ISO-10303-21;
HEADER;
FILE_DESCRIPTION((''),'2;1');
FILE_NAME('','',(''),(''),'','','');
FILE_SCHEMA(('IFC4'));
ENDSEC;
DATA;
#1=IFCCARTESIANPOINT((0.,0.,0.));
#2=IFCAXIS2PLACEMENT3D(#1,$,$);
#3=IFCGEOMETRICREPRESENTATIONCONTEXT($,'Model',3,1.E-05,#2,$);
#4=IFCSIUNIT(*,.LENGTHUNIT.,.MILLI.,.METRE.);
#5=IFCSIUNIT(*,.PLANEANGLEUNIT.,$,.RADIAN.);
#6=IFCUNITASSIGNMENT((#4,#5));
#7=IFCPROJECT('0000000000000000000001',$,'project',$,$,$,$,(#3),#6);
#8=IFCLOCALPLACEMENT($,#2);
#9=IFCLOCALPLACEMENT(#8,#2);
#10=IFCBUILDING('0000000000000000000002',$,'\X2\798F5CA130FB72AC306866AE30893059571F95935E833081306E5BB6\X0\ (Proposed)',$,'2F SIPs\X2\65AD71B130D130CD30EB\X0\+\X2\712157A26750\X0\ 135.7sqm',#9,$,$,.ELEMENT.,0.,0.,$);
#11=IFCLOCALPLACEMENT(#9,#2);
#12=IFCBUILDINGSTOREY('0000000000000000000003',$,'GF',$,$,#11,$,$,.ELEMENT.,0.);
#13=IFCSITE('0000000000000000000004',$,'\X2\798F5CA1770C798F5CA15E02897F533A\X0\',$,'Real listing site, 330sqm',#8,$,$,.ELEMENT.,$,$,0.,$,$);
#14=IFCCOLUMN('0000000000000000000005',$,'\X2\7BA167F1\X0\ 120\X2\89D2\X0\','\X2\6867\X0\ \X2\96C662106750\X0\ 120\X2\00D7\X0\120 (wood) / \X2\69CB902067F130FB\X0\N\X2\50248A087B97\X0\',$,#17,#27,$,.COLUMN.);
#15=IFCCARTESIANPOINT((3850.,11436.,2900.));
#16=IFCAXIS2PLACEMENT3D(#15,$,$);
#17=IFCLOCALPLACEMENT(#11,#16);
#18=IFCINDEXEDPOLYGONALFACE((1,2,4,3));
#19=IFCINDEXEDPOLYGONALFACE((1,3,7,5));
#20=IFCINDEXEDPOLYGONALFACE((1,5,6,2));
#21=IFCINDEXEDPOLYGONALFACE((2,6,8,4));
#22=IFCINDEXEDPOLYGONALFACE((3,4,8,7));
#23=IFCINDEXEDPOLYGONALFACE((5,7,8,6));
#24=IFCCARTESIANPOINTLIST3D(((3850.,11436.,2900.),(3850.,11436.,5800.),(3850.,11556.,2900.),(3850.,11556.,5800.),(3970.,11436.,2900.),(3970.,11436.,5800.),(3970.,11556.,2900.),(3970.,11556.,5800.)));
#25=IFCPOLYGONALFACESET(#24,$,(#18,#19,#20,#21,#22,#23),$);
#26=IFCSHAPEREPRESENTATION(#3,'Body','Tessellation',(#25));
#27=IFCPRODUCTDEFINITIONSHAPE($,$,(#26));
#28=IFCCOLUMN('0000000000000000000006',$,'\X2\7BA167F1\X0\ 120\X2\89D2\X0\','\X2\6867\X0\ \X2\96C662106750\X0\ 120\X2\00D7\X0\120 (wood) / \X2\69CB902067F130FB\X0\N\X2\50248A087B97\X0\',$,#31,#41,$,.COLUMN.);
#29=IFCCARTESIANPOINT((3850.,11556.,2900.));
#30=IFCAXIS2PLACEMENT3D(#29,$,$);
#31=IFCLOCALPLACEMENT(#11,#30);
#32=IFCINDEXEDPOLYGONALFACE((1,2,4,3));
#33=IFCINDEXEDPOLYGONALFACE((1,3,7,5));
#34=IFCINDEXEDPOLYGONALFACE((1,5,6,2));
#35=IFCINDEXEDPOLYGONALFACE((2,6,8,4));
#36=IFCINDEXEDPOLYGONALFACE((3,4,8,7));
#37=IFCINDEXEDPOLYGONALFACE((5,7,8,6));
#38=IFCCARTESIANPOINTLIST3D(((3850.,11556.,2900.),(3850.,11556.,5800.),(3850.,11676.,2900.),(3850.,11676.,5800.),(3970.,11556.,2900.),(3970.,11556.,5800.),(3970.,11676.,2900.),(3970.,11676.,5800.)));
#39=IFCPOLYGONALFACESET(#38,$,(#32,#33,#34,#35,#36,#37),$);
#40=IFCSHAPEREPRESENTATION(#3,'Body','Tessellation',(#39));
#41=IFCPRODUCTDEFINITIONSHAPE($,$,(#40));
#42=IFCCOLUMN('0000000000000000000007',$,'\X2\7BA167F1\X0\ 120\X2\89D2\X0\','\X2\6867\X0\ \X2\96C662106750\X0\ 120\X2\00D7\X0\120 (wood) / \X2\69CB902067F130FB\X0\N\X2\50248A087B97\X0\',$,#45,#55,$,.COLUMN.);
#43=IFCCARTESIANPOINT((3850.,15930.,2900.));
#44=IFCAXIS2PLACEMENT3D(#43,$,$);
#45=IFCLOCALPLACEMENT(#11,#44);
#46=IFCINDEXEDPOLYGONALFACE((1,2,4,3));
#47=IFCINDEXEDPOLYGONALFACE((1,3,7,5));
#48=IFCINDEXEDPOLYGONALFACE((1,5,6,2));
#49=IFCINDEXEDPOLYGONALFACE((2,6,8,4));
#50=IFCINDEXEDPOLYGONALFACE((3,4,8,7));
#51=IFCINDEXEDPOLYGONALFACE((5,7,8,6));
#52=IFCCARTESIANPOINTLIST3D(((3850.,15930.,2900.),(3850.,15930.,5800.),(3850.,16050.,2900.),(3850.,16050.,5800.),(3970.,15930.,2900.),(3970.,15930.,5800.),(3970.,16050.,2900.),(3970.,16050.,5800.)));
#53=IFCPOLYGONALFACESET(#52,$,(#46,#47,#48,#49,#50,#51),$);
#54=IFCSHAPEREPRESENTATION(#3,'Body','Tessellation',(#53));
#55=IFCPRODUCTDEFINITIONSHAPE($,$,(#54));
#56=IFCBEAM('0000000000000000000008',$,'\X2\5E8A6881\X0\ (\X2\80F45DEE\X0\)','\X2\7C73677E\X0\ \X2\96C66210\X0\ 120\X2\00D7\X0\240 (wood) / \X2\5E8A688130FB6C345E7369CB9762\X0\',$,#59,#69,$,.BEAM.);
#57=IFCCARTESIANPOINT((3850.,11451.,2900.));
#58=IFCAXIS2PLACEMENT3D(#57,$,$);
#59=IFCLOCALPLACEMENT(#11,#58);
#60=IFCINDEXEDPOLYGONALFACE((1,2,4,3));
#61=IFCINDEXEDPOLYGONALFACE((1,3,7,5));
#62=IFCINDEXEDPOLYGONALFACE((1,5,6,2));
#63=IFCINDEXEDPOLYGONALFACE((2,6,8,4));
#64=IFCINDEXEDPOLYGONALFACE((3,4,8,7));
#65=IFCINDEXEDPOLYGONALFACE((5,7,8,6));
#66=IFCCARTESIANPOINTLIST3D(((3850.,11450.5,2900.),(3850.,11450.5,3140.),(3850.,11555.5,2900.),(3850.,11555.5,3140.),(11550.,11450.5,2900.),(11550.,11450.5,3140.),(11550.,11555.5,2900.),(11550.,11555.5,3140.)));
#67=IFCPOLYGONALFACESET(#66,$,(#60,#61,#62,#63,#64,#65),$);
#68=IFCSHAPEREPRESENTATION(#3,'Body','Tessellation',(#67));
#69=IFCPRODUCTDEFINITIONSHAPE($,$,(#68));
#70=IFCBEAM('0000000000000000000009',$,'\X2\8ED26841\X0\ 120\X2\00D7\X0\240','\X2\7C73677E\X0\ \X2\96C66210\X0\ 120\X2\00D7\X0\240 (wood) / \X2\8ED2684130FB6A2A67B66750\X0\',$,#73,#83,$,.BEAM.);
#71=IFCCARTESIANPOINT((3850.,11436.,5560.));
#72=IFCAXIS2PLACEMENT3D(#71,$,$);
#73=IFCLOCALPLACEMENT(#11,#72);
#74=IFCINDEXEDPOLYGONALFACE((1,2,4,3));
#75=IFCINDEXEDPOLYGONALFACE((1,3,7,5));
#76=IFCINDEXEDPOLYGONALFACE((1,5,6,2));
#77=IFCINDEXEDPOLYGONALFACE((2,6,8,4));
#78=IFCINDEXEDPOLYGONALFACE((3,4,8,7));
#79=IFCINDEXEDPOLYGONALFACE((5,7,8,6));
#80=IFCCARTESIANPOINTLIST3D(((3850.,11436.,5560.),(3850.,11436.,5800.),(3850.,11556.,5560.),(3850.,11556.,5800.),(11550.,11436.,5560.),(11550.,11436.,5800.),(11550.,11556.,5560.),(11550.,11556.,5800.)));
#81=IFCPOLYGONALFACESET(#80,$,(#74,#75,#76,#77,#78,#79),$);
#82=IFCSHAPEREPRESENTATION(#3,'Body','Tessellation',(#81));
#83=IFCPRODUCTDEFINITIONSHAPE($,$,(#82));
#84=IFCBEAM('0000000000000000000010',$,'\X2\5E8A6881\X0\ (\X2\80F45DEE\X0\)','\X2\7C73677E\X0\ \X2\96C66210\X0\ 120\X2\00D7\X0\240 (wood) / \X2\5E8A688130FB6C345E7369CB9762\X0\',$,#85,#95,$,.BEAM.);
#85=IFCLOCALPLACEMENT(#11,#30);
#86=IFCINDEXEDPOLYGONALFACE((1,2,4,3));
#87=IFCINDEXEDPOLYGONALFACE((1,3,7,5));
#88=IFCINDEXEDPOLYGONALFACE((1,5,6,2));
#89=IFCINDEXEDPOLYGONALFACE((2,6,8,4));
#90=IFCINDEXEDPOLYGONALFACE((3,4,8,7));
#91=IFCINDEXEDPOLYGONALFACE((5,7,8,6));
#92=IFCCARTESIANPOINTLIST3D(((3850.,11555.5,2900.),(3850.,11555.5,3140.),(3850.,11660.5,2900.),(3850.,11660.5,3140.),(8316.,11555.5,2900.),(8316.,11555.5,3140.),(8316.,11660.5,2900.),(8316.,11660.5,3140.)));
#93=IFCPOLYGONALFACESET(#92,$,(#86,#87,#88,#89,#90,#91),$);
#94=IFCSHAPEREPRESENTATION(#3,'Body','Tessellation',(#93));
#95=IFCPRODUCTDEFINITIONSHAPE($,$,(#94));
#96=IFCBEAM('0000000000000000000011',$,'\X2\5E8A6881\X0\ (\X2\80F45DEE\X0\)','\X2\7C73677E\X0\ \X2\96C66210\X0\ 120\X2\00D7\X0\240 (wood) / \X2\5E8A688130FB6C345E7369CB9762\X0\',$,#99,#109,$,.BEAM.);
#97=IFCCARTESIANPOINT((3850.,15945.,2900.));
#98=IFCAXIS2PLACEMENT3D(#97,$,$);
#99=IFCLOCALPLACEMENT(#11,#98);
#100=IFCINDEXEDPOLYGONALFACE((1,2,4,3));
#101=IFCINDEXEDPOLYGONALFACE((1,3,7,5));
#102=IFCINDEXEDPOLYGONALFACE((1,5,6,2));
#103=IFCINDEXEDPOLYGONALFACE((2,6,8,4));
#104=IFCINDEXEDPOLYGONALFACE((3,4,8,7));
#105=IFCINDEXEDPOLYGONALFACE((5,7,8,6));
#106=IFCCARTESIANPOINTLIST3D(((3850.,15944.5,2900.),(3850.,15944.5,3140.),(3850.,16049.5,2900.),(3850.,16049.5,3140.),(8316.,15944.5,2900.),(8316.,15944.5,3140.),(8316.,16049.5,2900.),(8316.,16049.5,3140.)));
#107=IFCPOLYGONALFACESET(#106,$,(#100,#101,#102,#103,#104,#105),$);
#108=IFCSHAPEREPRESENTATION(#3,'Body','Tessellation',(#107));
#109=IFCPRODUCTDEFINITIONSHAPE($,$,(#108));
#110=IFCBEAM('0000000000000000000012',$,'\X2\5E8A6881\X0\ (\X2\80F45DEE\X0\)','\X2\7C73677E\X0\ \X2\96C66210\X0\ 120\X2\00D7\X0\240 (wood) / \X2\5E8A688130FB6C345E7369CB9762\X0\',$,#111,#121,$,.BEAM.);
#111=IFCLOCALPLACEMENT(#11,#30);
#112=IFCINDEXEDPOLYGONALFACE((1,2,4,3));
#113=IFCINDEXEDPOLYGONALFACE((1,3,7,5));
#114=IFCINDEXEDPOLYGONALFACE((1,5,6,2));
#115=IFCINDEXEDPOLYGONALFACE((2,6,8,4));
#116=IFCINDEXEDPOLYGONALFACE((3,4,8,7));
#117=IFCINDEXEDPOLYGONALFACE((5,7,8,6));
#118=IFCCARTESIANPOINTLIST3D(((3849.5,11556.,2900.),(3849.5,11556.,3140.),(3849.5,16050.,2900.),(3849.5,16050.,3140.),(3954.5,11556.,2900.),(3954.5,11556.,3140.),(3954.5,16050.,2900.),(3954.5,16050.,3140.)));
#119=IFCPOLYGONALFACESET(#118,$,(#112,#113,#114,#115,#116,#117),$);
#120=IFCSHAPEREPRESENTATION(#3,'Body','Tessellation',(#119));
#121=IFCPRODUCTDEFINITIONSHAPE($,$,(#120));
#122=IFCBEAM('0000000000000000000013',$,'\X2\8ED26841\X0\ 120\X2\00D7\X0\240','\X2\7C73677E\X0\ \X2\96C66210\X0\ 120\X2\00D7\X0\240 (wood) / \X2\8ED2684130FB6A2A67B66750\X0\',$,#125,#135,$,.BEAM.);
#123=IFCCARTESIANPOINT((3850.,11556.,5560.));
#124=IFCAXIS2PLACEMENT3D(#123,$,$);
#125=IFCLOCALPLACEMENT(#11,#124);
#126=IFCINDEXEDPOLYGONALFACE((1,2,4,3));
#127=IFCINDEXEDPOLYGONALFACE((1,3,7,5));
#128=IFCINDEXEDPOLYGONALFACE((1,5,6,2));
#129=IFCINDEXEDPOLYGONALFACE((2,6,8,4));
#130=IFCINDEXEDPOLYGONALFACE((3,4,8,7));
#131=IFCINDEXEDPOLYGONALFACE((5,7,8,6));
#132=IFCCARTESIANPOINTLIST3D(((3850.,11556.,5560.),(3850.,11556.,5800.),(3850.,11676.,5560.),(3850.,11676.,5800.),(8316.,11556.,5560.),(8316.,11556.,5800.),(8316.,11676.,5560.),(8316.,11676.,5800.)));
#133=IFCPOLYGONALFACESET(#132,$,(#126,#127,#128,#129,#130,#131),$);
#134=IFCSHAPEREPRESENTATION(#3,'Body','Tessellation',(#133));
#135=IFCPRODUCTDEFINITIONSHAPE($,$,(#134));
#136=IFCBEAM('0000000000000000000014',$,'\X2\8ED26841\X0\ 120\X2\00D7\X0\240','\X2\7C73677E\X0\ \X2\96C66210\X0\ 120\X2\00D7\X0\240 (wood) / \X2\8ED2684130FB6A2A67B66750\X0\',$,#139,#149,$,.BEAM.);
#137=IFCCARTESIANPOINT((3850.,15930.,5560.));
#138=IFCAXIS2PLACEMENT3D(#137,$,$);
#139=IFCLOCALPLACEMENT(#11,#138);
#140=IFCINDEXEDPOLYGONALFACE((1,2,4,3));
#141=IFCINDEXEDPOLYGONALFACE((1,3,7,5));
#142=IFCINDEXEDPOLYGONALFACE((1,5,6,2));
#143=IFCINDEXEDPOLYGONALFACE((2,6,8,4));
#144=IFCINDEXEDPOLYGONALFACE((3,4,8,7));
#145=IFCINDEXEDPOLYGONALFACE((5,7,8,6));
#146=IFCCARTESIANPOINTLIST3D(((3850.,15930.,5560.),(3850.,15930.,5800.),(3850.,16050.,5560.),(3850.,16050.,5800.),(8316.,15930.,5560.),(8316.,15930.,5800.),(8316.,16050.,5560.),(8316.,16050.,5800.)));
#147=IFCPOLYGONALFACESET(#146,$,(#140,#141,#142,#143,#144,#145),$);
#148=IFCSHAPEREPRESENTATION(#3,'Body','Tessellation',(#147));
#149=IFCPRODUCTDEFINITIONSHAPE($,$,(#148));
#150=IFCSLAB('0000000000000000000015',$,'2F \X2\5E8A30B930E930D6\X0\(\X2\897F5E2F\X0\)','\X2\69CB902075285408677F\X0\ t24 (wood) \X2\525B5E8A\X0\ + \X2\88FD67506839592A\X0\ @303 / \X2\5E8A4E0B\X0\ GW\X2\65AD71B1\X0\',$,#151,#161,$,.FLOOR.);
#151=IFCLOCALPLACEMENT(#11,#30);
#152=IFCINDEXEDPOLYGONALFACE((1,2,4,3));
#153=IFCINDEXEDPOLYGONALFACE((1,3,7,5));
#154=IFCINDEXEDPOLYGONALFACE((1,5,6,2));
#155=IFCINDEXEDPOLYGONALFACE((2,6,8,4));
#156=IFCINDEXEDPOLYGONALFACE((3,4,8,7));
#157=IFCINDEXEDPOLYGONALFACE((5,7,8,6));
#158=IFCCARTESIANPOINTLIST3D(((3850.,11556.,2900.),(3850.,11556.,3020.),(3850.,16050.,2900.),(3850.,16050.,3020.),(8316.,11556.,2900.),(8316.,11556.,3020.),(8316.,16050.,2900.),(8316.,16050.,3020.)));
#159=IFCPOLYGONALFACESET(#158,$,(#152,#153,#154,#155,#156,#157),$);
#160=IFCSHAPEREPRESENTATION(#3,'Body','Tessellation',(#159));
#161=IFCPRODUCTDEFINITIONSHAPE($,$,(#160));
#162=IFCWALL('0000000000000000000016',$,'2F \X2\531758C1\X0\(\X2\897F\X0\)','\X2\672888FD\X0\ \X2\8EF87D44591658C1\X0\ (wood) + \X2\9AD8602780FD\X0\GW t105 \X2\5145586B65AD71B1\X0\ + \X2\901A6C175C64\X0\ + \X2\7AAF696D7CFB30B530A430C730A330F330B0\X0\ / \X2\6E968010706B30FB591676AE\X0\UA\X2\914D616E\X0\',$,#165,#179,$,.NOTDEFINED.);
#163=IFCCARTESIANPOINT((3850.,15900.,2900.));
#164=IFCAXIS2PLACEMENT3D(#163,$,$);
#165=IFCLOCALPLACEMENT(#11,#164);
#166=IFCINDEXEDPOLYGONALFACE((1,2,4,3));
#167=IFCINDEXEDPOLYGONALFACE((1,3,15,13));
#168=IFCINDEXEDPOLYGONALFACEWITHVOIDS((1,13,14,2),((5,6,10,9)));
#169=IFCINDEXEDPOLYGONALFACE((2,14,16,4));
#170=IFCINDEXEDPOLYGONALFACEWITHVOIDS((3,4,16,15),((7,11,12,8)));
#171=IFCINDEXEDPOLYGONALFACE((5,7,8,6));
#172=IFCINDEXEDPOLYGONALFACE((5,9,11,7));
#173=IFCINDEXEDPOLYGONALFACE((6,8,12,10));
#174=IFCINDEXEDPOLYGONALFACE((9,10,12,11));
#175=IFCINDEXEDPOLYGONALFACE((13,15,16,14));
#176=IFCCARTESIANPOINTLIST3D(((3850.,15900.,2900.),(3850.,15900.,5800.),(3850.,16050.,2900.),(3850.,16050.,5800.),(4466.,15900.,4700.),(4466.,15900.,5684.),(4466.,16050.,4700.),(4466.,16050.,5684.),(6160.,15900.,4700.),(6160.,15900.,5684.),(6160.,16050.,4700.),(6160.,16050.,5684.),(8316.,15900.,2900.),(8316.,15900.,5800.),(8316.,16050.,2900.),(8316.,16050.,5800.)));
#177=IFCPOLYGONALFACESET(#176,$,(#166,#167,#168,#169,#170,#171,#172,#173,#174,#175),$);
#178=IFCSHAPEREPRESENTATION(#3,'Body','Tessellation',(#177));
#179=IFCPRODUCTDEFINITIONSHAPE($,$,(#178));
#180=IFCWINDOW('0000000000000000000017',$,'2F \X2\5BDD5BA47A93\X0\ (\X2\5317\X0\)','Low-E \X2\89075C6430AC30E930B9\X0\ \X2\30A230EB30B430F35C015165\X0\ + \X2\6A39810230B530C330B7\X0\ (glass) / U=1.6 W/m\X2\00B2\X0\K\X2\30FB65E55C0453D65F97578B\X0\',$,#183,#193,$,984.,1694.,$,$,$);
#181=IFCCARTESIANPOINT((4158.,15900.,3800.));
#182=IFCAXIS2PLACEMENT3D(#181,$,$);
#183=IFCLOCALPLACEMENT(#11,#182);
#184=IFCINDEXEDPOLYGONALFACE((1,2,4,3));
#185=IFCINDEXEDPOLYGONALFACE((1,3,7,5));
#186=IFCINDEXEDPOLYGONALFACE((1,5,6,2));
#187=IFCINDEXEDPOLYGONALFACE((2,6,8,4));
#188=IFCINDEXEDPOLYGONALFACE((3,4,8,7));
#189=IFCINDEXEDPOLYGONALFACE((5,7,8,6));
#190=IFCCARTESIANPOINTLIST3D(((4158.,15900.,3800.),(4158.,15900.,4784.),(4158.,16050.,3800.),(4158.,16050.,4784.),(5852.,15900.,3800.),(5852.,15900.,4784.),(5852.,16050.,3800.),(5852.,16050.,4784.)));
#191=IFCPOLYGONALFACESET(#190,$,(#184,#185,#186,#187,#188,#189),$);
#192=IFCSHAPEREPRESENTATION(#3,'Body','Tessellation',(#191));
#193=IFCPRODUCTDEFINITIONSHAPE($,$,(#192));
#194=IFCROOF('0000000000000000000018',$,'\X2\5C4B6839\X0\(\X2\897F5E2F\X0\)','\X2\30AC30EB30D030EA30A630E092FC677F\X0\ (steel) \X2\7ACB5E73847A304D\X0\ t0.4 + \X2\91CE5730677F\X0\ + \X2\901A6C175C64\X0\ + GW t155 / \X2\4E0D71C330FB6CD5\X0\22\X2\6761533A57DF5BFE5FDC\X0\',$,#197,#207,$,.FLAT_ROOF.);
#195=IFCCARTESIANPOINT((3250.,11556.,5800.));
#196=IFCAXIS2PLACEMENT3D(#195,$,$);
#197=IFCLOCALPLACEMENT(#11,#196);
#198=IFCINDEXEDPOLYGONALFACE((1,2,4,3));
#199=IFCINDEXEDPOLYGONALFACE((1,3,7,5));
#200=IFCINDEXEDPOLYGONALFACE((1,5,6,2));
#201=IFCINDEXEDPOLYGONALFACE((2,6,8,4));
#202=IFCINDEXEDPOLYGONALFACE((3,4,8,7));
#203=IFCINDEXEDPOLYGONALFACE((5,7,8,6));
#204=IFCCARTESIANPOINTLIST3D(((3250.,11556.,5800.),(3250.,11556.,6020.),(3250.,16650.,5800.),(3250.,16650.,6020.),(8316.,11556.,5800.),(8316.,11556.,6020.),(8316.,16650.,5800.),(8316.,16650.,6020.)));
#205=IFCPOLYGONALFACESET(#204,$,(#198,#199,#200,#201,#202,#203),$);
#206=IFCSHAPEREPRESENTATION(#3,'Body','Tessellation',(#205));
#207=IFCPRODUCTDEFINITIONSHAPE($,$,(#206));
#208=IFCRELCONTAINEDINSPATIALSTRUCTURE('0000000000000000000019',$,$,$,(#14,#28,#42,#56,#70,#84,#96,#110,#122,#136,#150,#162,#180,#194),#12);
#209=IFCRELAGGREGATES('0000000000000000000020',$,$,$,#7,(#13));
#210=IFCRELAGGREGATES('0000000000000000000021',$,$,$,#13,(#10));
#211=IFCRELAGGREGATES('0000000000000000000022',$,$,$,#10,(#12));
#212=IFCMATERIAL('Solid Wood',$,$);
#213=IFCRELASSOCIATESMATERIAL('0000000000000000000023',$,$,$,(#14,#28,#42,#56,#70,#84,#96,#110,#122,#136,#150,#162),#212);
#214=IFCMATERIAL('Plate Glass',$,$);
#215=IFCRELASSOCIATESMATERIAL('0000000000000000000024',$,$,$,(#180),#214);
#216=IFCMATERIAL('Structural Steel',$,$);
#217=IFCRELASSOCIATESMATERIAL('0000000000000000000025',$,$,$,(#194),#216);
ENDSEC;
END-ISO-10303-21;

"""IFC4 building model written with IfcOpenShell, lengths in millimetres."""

from ifc_helpers import new_model, si_unit, frame, frame_2d, origin, place, context, project, spatial, rectangle, extrude, material, element, fill, save


model = new_model("IFC4")

# Units and contexts
model_context = context("Model", 3, precision=1e-05, world=origin())
ifc_project = project(units=[si_unit("LENGTHUNIT", "METRE", prefix="MILLI"), si_unit("PLANEANGLEUNIT", "RADIAN")], contexts=[model_context])

# Site, building, storey
site_placement = place(None, origin())
site = spatial("IfcSite", under=ifc_project, at=site_placement, Name="福岡県福岡市西区", ObjectType="Real listing site, 330sqm", CompositionType="ELEMENT", RefElevation=0.0)
building_placement = place(site_placement, origin())
building = spatial("IfcBuilding", under=site, at=building_placement, Name="福岡・犬と暮らす土間広めの家 (Proposed)", ObjectType="2F SIPs断熱パネル+無垢材 135.7sqm", CompositionType="ELEMENT", ElevationOfRefHeight=0.0, ElevationOfTerrain=0.0)
storey_placement = place(building_placement, origin())
storey = spatial("IfcBuildingStorey", under=building, at=storey_placement, Name="GF", CompositionType="ELEMENT", Elevation=0.0)

# Columns
ifc_material_1 = material(Name="Solid Wood")
column_1_placement = place(storey_placement, frame((3850.0, 11436.0, 2900.0)))
element("IfcColumn", 1, at=column_1_placement, inside=storey, material=ifc_material_1, Name="管柱 120角", Description="桧 集成材 120×120 (wood) / 構造柱・N値計算", PredefinedType="COLUMN", context=model_context, shape_type="SweptSolid", body=[
    extrude(rectangle(XDim=120.0, YDim=120.0, at=frame_2d((60.0, 60.0))), frame((3850.0, 11436.0, 2900.0)), (0.0, 0.0, 1.0), 2900.0),
])
column_2_placement = place(storey_placement, frame((3850.0, 11556.0, 2900.0)))
element("IfcColumn", 2, at=column_2_placement, inside=storey, material=ifc_material_1, Name="管柱 120角", Description="桧 集成材 120×120 (wood) / 構造柱・N値計算", PredefinedType="COLUMN", context=model_context, shape_type="SweptSolid", body=[
    extrude(rectangle(XDim=120.0, YDim=120.0, at=frame_2d((60.0, 60.0))), frame((3850.0, 11556.0, 2900.0)), (0.0, 0.0, 1.0), 2900.0),
])
column_3_placement = place(storey_placement, frame((3850.0, 15930.0, 2900.0)))
element("IfcColumn", 3, at=column_3_placement, inside=storey, material=ifc_material_1, Name="管柱 120角", Description="桧 集成材 120×120 (wood) / 構造柱・N値計算", PredefinedType="COLUMN", context=model_context, shape_type="SweptSolid", body=[
    extrude(rectangle(XDim=120.0, YDim=120.0, at=frame_2d((60.0, 60.0))), frame((3850.0, 15930.0, 2900.0)), (0.0, 0.0, 1.0), 2900.0),
])

# Beams
beam_1_placement = place(storey_placement, frame((3850.0, 11451.0, 2900.0)))
element("IfcBeam", 4, at=beam_1_placement, inside=storey, material=ifc_material_1, Name="床梁 (胴差)", Description="米松 集成 120×240 (wood) / 床梁・水平構面", PredefinedType="BEAM", context=model_context, shape_type="SweptSolid", body=[
    extrude(rectangle(XDim=7700.0, YDim=105.0, at=frame_2d((3850.0, 52.0))), frame((3850.0, 11451.0, 2900.0)), (0.0, 0.0, 1.0), 240.0),
])
beam_2_placement = place(storey_placement, frame((3850.0, 11436.0, 5560.0)))
element("IfcBeam", 5, at=beam_2_placement, inside=storey, material=ifc_material_1, Name="軒桁 120×240", Description="米松 集成 120×240 (wood) / 軒桁・横架材", PredefinedType="BEAM", context=model_context, shape_type="SweptSolid", body=[
    extrude(rectangle(XDim=7700.0, YDim=120.0, at=frame_2d((3850.0, 60.0))), frame((3850.0, 11436.0, 5560.0)), (0.0, 0.0, 1.0), 240.0),
])
beam_3_placement = place(storey_placement, frame((3850.0, 11556.0, 2900.0)))
element("IfcBeam", 6, at=beam_3_placement, inside=storey, material=ifc_material_1, Name="床梁 (胴差)", Description="米松 集成 120×240 (wood) / 床梁・水平構面", PredefinedType="BEAM", context=model_context, shape_type="SweptSolid", body=[
    extrude(rectangle(XDim=4466.0, YDim=105.0, at=frame_2d((2233.0, 52.0))), frame((3850.0, 11556.0, 2900.0)), (0.0, 0.0, 1.0), 240.0),
])
beam_4_placement = place(storey_placement, frame((3850.0, 15945.0, 2900.0)))
element("IfcBeam", 7, at=beam_4_placement, inside=storey, material=ifc_material_1, Name="床梁 (胴差)", Description="米松 集成 120×240 (wood) / 床梁・水平構面", PredefinedType="BEAM", context=model_context, shape_type="SweptSolid", body=[
    extrude(rectangle(XDim=4466.0, YDim=105.0, at=frame_2d((2233.0, 52.0))), frame((3850.0, 15945.0, 2900.0)), (0.0, 0.0, 1.0), 240.0),
])
beam_5_placement = place(storey_placement, frame((3850.0, 11556.0, 2900.0)))
element("IfcBeam", 8, at=beam_5_placement, inside=storey, material=ifc_material_1, Name="床梁 (胴差)", Description="米松 集成 120×240 (wood) / 床梁・水平構面", PredefinedType="BEAM", context=model_context, shape_type="SweptSolid", body=[
    extrude(rectangle(XDim=105.0, YDim=4494.0, at=frame_2d((52.0, 2247.0))), frame((3850.0, 11556.0, 2900.0)), (0.0, 0.0, 1.0), 240.0),
])
beam_6_placement = place(storey_placement, frame((3850.0, 11556.0, 5560.0)))
element("IfcBeam", 9, at=beam_6_placement, inside=storey, material=ifc_material_1, Name="軒桁 120×240", Description="米松 集成 120×240 (wood) / 軒桁・横架材", PredefinedType="BEAM", context=model_context, shape_type="SweptSolid", body=[
    extrude(rectangle(XDim=4466.0, YDim=120.0, at=frame_2d((2233.0, 60.0))), frame((3850.0, 11556.0, 5560.0)), (0.0, 0.0, 1.0), 240.0),
])
beam_7_placement = place(storey_placement, frame((3850.0, 15930.0, 5560.0)))
element("IfcBeam", 10, at=beam_7_placement, inside=storey, material=ifc_material_1, Name="軒桁 120×240", Description="米松 集成 120×240 (wood) / 軒桁・横架材", PredefinedType="BEAM", context=model_context, shape_type="SweptSolid", body=[
    extrude(rectangle(XDim=4466.0, YDim=120.0, at=frame_2d((2233.0, 60.0))), frame((3850.0, 15930.0, 5560.0)), (0.0, 0.0, 1.0), 240.0),
])

# Slab
slab_placement = place(storey_placement, frame((3850.0, 11556.0, 2900.0)))
element("IfcSlab", 11, at=slab_placement, inside=storey, material=ifc_material_1, Name="2F 床スラブ(西帯)", Description="構造用合板 t24 (wood) 剛床 + 製材根太 @303 / 床下 GW断熱", PredefinedType="FLOOR", context=model_context, shape_type="SweptSolid", body=[
    extrude(rectangle(XDim=4466.0, YDim=4494.0, at=frame_2d((2233.0, 2247.0))), frame((3850.0, 11556.0, 2900.0)), (0.0, 0.0, 1.0), 120.0),
])

# Wall, opening, window
wall_1_placement = place(storey_placement, frame((3850.0, 15900.0, 2900.0)))
wall_1 = element("IfcWall", 12, at=wall_1_placement, inside=storey, material=ifc_material_1, Name="2F 北壁(西)", Description="木製 軸組外壁 (wood) + 高性能GW t105 充填断熱 + 通気層 + 窯業系サイディング / 準耐火・外皮UA配慮", PredefinedType="NOTDEFINED", context=model_context, shape_type="SweptSolid", body=[
    extrude(rectangle(XDim=4466.0, YDim=150.0, at=frame_2d((2233.0, 75.0))), frame((3850.0, 15900.0, 2900.0)), (0.0, 0.0, 1.0), 2900.0),
])
opening_placement = place(storey_placement, frame((4158.0, 15900.0, 3800.0)))
opening = element("IfcOpeningElement", 13, at=opening_placement, cuts=wall_1, PredefinedType="NOTDEFINED", context=model_context, shape_type="SweptSolid", body=[
    extrude(rectangle(XDim=1694.0, YDim=150.0, at=frame_2d((847.0, 75.0))), frame((4158.0, 15900.0, 3800.0)), (0.0, 0.0, 1.0), 984.0),
])
ifc_material_2 = material(Name="Plate Glass")
window_placement = place(storey_placement, frame((4158.0, 15900.0, 3800.0)))
window = element("IfcWindow", 14, at=window_placement, inside=storey, material=ifc_material_2, Name="2F 寝室窓 (北)", Description="Low-E 複層ガラス アルゴン封入 + 樹脂サッシ (glass) / U=1.6 W/m²K・日射取得型", OverallHeight=984.0, OverallWidth=1694.0, context=model_context, shape_type="SweptSolid", body=[
    extrude(rectangle(XDim=1694.0, YDim=150.0, at=frame_2d((847.0, 75.0))), frame((4158.0, 15900.0, 3800.0)), (0.0, 0.0, 1.0), 984.0),
])
fill(opening, window)

# Roof
ifc_material_3 = material(Name="Structural Steel")
for number, where, name in (
    (15, (3250.0, 11556.0, 5800.0), "屋根(西帯)"),
):
    element("IfcRoof", number, at=place(storey_placement, frame(where)), inside=storey, material=ifc_material_3, Name=name, Description="ガルバリウム鋼板 (steel) 立平葺き t0.4 + 野地板 + 通気層 + GW t155 / 不燃・法22条区域対応", PredefinedType="FLAT_ROOF", context=model_context, shape_type="SweptSolid", body=[
        extrude(rectangle(XDim=5066.0, YDim=5094.0, at=frame_2d((2533.0, 2547.0))), frame((3250.0, 11556.0, 5800.0)), (0.0, 0.0, 1.0), 220.0),
    ])

save(model, "model.ifc")
